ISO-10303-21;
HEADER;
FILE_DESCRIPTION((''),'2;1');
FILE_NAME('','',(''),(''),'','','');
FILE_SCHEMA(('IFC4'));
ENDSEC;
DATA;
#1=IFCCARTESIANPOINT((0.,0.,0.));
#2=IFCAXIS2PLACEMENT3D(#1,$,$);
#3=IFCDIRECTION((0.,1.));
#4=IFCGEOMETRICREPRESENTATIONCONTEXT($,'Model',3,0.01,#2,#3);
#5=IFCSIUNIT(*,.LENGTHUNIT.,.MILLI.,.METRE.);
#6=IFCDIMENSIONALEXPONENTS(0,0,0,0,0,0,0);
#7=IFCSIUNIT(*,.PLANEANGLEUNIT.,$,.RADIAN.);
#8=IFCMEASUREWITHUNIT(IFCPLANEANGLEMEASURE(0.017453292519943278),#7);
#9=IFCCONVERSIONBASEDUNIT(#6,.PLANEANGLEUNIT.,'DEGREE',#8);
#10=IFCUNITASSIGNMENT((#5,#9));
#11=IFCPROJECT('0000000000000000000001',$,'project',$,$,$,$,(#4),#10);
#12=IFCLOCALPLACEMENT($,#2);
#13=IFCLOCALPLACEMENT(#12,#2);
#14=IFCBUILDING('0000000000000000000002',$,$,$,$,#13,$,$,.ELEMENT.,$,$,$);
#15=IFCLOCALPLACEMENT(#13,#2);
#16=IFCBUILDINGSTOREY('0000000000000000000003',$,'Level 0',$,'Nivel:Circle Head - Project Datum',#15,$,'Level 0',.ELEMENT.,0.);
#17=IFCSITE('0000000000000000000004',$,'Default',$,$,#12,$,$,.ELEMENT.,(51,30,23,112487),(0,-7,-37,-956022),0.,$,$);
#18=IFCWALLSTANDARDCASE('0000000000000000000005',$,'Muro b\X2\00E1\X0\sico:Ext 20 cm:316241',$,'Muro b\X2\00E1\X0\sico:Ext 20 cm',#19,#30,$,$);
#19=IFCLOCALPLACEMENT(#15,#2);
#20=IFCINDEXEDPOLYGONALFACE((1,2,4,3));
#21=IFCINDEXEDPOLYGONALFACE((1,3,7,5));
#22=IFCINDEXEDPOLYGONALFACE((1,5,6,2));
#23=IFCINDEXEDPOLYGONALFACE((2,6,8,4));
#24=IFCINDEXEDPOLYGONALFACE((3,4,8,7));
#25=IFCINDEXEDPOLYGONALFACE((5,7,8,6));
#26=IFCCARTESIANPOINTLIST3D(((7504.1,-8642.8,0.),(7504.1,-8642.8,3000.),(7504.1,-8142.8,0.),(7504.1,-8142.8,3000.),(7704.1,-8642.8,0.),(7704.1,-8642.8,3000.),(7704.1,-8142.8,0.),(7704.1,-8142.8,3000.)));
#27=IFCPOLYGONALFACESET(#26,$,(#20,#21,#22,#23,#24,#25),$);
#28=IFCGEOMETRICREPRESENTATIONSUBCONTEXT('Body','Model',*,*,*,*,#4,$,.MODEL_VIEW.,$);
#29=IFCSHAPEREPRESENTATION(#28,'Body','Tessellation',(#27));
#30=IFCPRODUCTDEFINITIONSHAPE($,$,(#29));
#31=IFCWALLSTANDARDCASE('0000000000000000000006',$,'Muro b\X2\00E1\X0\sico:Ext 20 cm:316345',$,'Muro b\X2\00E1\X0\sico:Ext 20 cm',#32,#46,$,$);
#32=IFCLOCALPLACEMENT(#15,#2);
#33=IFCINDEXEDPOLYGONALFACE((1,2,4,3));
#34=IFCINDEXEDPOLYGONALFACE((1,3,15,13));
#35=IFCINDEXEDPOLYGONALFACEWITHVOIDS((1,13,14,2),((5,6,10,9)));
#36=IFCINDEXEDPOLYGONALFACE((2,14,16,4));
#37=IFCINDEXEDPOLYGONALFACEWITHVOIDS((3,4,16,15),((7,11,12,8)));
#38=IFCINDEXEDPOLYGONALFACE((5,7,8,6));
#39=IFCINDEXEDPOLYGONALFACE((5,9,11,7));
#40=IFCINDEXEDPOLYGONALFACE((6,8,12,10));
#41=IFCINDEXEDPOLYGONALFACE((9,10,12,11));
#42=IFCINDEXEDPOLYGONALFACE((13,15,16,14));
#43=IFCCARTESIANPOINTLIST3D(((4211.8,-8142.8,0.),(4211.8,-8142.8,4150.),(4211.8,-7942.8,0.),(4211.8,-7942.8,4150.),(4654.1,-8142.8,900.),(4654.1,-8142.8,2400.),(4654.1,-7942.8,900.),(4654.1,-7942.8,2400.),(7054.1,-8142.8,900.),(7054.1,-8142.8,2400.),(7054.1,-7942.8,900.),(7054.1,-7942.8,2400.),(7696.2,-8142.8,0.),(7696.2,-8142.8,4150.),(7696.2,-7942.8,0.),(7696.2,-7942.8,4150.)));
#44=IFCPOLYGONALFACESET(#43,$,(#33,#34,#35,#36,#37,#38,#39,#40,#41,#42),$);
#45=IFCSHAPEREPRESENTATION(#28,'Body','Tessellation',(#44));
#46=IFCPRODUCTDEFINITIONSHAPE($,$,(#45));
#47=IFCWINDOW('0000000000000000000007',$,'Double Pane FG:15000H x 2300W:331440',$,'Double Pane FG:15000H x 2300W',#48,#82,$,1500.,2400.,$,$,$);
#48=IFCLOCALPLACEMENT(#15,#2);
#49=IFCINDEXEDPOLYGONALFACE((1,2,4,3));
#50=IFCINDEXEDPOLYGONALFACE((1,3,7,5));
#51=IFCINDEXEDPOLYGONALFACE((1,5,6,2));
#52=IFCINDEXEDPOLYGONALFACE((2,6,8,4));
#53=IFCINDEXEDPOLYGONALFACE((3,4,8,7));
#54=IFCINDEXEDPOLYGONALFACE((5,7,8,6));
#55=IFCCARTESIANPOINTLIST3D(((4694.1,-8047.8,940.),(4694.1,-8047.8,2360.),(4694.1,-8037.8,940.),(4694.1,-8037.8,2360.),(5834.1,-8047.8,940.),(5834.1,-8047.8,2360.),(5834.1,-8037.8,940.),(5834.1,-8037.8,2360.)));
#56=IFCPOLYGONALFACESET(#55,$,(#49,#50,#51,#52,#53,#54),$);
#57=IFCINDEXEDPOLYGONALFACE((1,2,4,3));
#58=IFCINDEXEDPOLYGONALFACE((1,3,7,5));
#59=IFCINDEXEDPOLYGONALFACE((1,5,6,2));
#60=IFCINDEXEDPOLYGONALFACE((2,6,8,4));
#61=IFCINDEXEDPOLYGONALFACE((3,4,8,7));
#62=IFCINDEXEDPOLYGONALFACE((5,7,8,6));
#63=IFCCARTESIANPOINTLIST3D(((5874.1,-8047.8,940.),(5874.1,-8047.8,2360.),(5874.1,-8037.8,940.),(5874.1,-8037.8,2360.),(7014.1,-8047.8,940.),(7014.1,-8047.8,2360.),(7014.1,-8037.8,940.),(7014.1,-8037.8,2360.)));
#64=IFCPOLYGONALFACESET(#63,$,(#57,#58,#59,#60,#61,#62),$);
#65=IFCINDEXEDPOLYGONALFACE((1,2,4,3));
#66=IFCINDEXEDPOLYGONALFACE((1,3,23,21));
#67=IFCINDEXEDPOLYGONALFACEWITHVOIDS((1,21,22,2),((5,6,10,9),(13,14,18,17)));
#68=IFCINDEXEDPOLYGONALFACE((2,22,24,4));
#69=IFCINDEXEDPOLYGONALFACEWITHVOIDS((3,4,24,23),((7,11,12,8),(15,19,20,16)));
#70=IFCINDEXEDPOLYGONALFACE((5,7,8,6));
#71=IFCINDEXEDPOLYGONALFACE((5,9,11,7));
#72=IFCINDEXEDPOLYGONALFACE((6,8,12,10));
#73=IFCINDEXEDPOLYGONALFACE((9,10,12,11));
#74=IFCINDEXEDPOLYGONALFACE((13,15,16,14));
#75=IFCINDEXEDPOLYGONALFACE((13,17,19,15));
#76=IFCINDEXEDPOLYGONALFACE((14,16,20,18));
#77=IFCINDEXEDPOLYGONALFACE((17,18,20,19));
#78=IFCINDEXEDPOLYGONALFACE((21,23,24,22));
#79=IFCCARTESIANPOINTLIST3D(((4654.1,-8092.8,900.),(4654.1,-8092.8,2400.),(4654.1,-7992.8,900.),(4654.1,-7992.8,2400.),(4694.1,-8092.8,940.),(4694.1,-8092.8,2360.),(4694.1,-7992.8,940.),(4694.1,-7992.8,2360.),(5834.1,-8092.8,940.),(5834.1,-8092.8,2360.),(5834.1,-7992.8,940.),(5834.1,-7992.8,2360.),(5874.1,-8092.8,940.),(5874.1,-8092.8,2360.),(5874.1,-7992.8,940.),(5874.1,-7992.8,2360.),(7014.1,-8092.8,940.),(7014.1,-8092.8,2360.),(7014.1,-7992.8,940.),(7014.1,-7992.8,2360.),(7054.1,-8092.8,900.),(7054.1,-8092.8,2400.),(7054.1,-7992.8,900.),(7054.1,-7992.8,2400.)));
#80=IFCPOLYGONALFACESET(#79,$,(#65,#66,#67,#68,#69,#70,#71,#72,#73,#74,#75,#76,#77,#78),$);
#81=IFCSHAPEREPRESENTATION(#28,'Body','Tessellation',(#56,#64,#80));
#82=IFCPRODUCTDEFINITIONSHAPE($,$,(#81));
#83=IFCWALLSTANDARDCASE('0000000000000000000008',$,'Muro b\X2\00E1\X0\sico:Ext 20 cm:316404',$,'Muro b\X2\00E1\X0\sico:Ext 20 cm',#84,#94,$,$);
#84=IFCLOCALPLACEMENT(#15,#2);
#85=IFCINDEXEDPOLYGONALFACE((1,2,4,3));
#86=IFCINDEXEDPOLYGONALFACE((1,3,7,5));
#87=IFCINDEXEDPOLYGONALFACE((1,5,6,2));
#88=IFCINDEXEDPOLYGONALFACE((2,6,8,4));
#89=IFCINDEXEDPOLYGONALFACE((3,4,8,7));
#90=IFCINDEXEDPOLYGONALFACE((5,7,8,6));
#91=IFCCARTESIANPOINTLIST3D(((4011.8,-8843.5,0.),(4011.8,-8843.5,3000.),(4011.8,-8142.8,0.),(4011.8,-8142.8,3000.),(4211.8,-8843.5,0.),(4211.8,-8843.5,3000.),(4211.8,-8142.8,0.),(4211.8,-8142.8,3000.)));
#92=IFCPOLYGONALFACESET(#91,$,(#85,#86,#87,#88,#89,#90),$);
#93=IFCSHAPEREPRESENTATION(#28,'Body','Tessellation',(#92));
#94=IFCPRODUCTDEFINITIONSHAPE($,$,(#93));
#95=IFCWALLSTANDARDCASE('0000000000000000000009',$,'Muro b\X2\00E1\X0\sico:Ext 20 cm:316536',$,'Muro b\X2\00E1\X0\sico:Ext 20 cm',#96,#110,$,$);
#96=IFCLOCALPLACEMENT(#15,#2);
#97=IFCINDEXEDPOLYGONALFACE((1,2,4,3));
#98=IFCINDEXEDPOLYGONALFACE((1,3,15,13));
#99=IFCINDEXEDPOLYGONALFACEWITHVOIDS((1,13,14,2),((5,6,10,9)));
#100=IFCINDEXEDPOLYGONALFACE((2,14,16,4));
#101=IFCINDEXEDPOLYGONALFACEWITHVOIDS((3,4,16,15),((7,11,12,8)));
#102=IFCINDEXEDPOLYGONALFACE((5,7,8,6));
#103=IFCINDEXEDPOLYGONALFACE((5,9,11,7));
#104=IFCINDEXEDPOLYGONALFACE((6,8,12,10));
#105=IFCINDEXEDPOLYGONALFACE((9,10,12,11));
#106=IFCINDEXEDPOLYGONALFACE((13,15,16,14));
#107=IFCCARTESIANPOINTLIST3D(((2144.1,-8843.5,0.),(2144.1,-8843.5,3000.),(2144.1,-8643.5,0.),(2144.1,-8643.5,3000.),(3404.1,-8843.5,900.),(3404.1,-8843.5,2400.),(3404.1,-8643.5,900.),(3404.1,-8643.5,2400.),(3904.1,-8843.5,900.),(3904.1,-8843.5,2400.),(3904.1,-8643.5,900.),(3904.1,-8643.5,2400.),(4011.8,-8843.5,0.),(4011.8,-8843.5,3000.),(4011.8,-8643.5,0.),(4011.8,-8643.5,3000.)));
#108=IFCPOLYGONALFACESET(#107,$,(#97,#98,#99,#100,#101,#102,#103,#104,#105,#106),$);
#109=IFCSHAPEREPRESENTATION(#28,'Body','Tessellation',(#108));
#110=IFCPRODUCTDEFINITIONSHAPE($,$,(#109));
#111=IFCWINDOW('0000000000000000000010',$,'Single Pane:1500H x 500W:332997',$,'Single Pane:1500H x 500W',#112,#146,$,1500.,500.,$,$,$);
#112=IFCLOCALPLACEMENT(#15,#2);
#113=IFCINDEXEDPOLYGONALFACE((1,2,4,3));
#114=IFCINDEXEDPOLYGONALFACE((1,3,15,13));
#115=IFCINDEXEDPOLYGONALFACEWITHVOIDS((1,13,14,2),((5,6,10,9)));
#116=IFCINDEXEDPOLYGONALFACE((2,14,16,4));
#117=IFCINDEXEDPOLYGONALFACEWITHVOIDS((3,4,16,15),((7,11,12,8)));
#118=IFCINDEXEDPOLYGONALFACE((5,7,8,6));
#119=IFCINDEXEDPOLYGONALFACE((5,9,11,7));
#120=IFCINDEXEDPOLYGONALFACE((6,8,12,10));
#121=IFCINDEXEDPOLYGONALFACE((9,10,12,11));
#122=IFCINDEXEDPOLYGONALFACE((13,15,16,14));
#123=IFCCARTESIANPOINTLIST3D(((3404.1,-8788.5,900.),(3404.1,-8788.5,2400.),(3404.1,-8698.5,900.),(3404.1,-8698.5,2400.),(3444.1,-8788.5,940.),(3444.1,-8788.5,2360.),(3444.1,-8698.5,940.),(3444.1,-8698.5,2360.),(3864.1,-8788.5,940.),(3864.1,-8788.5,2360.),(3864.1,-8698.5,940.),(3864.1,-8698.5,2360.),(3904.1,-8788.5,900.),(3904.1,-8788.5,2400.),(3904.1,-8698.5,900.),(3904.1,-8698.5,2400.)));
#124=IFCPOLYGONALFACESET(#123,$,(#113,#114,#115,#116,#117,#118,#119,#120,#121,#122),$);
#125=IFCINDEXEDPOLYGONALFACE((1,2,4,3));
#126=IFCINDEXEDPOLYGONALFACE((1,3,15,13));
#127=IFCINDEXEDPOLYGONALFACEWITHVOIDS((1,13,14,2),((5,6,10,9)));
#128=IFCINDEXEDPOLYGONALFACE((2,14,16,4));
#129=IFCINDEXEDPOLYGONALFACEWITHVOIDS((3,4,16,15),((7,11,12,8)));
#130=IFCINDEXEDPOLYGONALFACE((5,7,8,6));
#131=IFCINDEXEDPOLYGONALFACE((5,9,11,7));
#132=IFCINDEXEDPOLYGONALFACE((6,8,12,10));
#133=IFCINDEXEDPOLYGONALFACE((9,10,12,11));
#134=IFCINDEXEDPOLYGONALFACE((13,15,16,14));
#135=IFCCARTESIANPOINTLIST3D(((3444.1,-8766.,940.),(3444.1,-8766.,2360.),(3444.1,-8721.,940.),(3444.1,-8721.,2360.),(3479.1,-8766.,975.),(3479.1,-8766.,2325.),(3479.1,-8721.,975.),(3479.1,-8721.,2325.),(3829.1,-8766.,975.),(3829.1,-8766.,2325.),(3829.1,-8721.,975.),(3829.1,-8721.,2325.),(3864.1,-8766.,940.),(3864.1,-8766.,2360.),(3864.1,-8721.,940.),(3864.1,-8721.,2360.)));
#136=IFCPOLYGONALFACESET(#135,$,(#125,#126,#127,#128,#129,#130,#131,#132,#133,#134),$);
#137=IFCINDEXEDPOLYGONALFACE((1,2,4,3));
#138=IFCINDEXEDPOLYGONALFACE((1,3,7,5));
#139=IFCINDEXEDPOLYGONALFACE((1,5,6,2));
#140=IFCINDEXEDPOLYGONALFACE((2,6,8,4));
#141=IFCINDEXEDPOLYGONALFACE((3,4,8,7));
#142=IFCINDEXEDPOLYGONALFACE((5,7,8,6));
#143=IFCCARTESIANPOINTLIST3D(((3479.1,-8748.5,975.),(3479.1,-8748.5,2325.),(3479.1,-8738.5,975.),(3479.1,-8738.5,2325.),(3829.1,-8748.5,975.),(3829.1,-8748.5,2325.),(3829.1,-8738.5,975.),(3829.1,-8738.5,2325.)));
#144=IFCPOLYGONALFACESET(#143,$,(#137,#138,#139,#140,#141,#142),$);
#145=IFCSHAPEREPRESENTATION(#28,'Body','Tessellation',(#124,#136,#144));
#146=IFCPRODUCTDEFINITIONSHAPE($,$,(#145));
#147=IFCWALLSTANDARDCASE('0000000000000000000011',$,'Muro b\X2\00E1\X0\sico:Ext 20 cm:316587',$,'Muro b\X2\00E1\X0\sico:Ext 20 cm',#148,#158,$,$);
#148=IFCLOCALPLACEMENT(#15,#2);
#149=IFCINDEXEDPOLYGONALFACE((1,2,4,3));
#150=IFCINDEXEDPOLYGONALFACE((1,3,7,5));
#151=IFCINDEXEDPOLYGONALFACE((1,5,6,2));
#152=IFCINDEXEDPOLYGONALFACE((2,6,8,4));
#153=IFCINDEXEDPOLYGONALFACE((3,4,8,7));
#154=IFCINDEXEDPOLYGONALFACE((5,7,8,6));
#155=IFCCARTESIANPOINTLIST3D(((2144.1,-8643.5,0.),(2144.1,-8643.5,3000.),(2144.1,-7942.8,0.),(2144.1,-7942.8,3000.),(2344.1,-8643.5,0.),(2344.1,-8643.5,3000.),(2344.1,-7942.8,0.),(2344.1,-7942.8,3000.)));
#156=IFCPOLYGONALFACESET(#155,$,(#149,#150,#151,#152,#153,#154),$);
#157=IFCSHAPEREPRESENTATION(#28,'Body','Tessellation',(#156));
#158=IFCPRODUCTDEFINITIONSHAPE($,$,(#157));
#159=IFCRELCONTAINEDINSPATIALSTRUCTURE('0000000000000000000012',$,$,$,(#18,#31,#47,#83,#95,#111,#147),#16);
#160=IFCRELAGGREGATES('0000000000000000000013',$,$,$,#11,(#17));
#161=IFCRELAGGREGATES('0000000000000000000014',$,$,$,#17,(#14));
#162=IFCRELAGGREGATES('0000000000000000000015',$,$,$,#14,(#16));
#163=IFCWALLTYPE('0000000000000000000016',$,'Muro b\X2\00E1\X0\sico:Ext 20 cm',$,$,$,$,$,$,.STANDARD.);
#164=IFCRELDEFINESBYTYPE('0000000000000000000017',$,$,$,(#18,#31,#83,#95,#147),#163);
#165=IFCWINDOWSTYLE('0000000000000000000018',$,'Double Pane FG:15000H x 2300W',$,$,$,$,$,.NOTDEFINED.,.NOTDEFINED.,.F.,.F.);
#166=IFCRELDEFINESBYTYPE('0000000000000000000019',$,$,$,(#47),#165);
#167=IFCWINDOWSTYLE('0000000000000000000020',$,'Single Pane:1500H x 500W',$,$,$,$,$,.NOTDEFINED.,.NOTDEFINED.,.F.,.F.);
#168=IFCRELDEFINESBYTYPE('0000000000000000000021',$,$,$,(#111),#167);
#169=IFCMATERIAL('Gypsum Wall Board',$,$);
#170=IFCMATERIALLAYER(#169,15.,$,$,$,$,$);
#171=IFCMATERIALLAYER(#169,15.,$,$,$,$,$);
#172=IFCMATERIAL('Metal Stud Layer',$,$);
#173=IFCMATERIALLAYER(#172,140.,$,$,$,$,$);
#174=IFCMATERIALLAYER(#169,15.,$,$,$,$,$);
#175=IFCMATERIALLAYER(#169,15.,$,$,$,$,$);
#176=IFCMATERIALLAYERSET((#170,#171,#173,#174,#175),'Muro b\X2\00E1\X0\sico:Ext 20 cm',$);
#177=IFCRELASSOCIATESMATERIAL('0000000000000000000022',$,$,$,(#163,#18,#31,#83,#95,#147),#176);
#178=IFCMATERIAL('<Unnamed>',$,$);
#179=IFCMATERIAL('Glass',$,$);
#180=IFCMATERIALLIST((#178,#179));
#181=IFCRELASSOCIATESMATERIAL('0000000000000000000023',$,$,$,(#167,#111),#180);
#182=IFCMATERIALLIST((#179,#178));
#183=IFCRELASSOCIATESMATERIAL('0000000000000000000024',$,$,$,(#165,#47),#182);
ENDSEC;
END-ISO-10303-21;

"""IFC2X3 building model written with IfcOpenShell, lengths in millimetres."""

from ifc_helpers import new_model, entity, si_unit, converted_unit, direction, frame, frame_2d, origin, origin_2d_with_axis, place, context, subcontext, project, spatial, polyline, rectangle, outline, extrude, source, transform, mapped, material, material_list, layer, layer_set, layer_usage, type_object, type_shapes, element, fill, save


model = new_model("IFC2X3")

# Units and contexts
model_context = context("Model", 3, precision=0.01, world=origin(), true_north=direction((0.0, 1.0)))
body_context = subcontext(model_context, "Body", "Model", "MODEL_VIEW")
ifc_project = project(units=[si_unit("LENGTHUNIT", "METRE", prefix="MILLI"), converted_unit("PLANEANGLEUNIT", "DEGREE", entity("IfcPlaneAngleMeasure", 0.017453292519943278), si_unit("PLANEANGLEUNIT", "RADIAN"), dimensions=[0, 0, 0, 0, 0, 0, 0])], contexts=[model_context])

# Site, building, storey
site_placement = place(None, origin())
site = spatial("IfcSite", under=ifc_project, at=site_placement, Name="Default", CompositionType="ELEMENT", RefLatitude=(51, 30, 23, 112487), RefLongitude=(0, -7, -37, -956022), RefElevation=0.0)
building_placement = place(site_placement, origin())
building = spatial("IfcBuilding", under=site, at=building_placement, CompositionType="ELEMENT")
storey_placement = place(building_placement, origin())
storey = spatial("IfcBuildingStorey", under=building, at=storey_placement, Name="Level 0", ObjectType="Nivel:Circle Head - Project Datum", LongName="Level 0", CompositionType="ELEMENT", Elevation=0.0)

# Shared definitions
ifc_material_1 = material(Name="Gypsum Wall Board")
ifc_layer_1 = layer(ifc_material_1, 15.0)
ifc_layer_2 = layer(ifc_material_1, 15.0)
ifc_material_2 = material(Name="Metal Stud Layer")
ifc_layer_3 = layer(ifc_material_2, 140.0)
ifc_layer_4 = layer(ifc_material_1, 15.0)
ifc_layer_5 = layer(ifc_material_1, 15.0)
ifc_layer_set_1 = layer_set([ifc_layer_1, ifc_layer_2, ifc_layer_3, ifc_layer_4, ifc_layer_5], Name="Muro básico:Ext 20 cm")
wall_type_1 = type_object("IfcWallType", Name="Muro básico:Ext 20 cm", PredefinedType="STANDARD", material=ifc_layer_set_1)
ifc_material_3 = material(Name="Glass")
ifc_material_4 = material(Name="<Unnamed>")
ifc_material_list_1 = material_list([ifc_material_3, ifc_material_4])

# Shared definitions
ifc_material_list_2 = material_list([ifc_material_4, ifc_material_3])

# Shared definitions
window_style_1 = type_object("IfcWindowStyle", Name="Single Pane:1500H x 500W", ConstructionType="NOTDEFINED", OperationType="NOTDEFINED", ParameterTakesPrecedence=False, Sizeable=False, material=ifc_material_list_2)
shared_shape_1 = source(origin(), body_context, "Body", "SweptSolid", [
    extrude(outline(polyline([(-250.0, -750.0), (250.0, -750.0), (250.0, 750.0), (-250.0, 750.0), (-250.0, -750.0)]), holes=[polyline([(-210.0, -710.0), (-210.0, 710.0), (210.0, 710.0), (210.0, -710.0), (-210.0, -710.0)])]), frame((250.0, 55.0, 750.0), z_axis=(0.0, 1.0, 0.0), x_axis=(1.0, 0.0, 0.0)), (0.0, 0.0, 1.0), 90.0),
    extrude(outline(polyline([(-210.0, -710.0), (210.0, -710.0), (210.0, 710.0), (-210.0, 710.0), (-210.0, -710.0)]), holes=[polyline([(-175.0, -675.0), (-175.0, 675.0), (175.0, 675.0), (175.0, -675.0), (-175.0, -675.0)])]), frame((250.0, 77.5, 750.0), z_axis=(0.0, 1.0, 0.0), x_axis=(1.0, 0.0, 0.0)), (0.0, 0.0, 1.0), 45.0),
    extrude(rectangle(XDim=10.0, YDim=350.0, at=origin_2d_with_axis()), frame((250.0, 100.0, 75.0), z_axis=(0.0, 0.0, 1.0), x_axis=(0.0, 1.0, 0.0)), (0.0, 0.0, 1.0), 1350.0),
])
type_shapes(window_style_1, [shared_shape_1])

# Wall
ifc_layer_usage_1 = layer_usage(ifc_layer_set_1, "AXIS2", "NEGATIVE", 100.0)
wall_1_placement = place(storey_placement, frame((7604.1, -8642.8, 0.0), z_axis=(0.0, 0.0, 1.0), x_axis=(0.0, 1.0, 0.0)))
element("IfcWallStandardCase", 1, at=wall_1_placement, inside=storey, type_object=wall_type_1, material=ifc_layer_usage_1, Name="Muro básico:Ext 20 cm:316241", ObjectType="Muro básico:Ext 20 cm", context=body_context, shape_type="SweptSolid", body=[
    extrude(rectangle(XDim=500.0, YDim=200.0, at=frame_2d((250.0, 0.0), x_axis=(-1.0, 0.0))), origin(), (0.0, 0.0, 1.0), 3000.0),
])

# Wall, opening, window
ifc_layer_usage_2 = layer_usage(ifc_layer_set_1, "AXIS2", "NEGATIVE", 100.0)
wall_2_placement = place(storey_placement, frame((7696.2, -8042.8, 0.0), z_axis=(0.0, 0.0, 1.0), x_axis=(-1.0, 0.0, 0.0)))
wall_2 = element("IfcWallStandardCase", 2, at=wall_2_placement, inside=storey, type_object=wall_type_1, material=ifc_layer_usage_2, Name="Muro básico:Ext 20 cm:316345", ObjectType="Muro básico:Ext 20 cm", context=body_context, shape_type="SweptSolid", body=[
    extrude(rectangle(XDim=3484.5, YDim=200.0, at=frame_2d((1742.2, 0.0), x_axis=(-1.0, 0.0))), origin(), (0.0, 0.0, 1.0), 4150.0),
])
opening_1_placement = place(wall_2_placement, frame((642.1, -100.0, 900.0)))
opening_1 = element("IfcOpeningElement", 3, at=opening_1_placement, cuts=wall_2, ObjectType="Opening", context=body_context, shape_type="SweptSolid", body=[
    extrude(rectangle(XDim=1500.0, YDim=2400.0, at=frame_2d((750.0, 1200.0), x_axis=(1.0, 0.0))), frame((0.0, 0.0, 0.0), z_axis=(0.0, 1.0, 0.0), x_axis=(0.0, 0.0, 1.0)), (0.0, 0.0, 1.0), 200.0),
])
window_style_2 = type_object("IfcWindowStyle", Name="Double Pane FG:15000H x 2300W", ConstructionType="NOTDEFINED", OperationType="NOTDEFINED", ParameterTakesPrecedence=False, Sizeable=False, material=ifc_material_list_1)
shared_shape_2 = source(origin(), body_context, "Body", "SweptSolid", [
    extrude(rectangle(XDim=10.0, YDim=1140.0, at=origin_2d_with_axis()), frame((1790.0, 100.0, 40.0), z_axis=(0.0, 0.0, 1.0), x_axis=(0.0, 1.0, 0.0)), (0.0, 0.0, 1.0), 1420.0),
    extrude(rectangle(XDim=10.0, YDim=1140.0, at=origin_2d_with_axis()), frame((610.0, 100.0, 40.0), z_axis=(0.0, 0.0, 1.0), x_axis=(0.0, 1.0, 0.0)), (0.0, 0.0, 1.0), 1420.0),
    extrude(outline(polyline([(-750.0, -1200.0), (750.0, -1200.0), (750.0, 1200.0), (-750.0, 1200.0), (-750.0, -1200.0)]), holes=[polyline([(710.0, -20.0), (710.0, -1160.0), (-710.0, -1160.0), (-710.0, -20.0), (710.0, -20.0)]), polyline([(-710.0, 20.0), (-710.0, 1160.0), (710.0, 1160.0), (710.0, 20.0), (-710.0, 20.0)])]), frame((1200.0, 50.0, 750.0), z_axis=(0.0, 1.0, 0.0), x_axis=(0.0, 0.0, -1.0)), (0.0, 0.0, 1.0), 100.0),
])
type_shapes(window_style_2, [shared_shape_2])
window_1_placement = place(opening_1_placement, origin())
window_1 = element("IfcWindow", 4, at=window_1_placement, inside=storey, type_object=window_style_2, material=ifc_material_list_1, Name="Double Pane FG:15000H x 2300W:331440", ObjectType="Double Pane FG:15000H x 2300W", OverallHeight=1500.0, OverallWidth=2400.0, context=body_context, shape_type="MappedRepresentation", body=[
    mapped(shared_shape_2, transform((0.0, 0.0, 0.0), scale=1.0)),
])
fill(opening_1, window_1)

# Wall
ifc_layer_usage_3 = layer_usage(ifc_layer_set_1, "AXIS2", "NEGATIVE", 100.0)
wall_3_placement = place(storey_placement, frame((4111.8, -8142.8, 0.0), z_axis=(0.0, 0.0, 1.0), x_axis=(0.0, -1.0, 0.0)))
element("IfcWallStandardCase", 5, at=wall_3_placement, inside=storey, type_object=wall_type_1, material=ifc_layer_usage_3, Name="Muro básico:Ext 20 cm:316404", ObjectType="Muro básico:Ext 20 cm", context=body_context, shape_type="SweptSolid", body=[
    extrude(rectangle(XDim=700.7, YDim=200.0, at=frame_2d((350.4, 0.0), x_axis=(-1.0, 0.0))), origin(), (0.0, 0.0, 1.0), 3000.0),
])

# Wall, opening, window
ifc_layer_usage_4 = layer_usage(ifc_layer_set_1, "AXIS2", "NEGATIVE", 100.0)
wall_4_placement = place(storey_placement, frame((4011.8, -8743.5, 0.0), z_axis=(0.0, 0.0, 1.0), x_axis=(-1.0, 0.0, 0.0)))
wall_4 = element("IfcWallStandardCase", 6, at=wall_4_placement, inside=storey, type_object=wall_type_1, material=ifc_layer_usage_4, Name="Muro básico:Ext 20 cm:316536", ObjectType="Muro básico:Ext 20 cm", context=body_context, shape_type="SweptSolid", body=[
    extrude(rectangle(XDim=1867.7, YDim=200.0, at=frame_2d((933.8, 0.0), x_axis=(-1.0, 0.0))), origin(), (0.0, 0.0, 1.0), 3000.0),
])
opening_2_placement = place(wall_4_placement, frame((607.7, 100.0, 900.0)))
opening_2 = element("IfcOpeningElement", 7, at=opening_2_placement, cuts=wall_4, ObjectType="Opening", context=body_context, shape_type="SweptSolid", body=[
    extrude(rectangle(XDim=1500.0, YDim=500.0, at=frame_2d((750.0, 250.0), x_axis=(1.0, 0.0))), frame((0.0, 0.0, 0.0), z_axis=(0.0, -1.0, 0.0), x_axis=(0.0, 0.0, 1.0)), (0.0, 0.0, 1.0), 200.0),
])
window_2_placement = place(opening_2_placement, frame((0.0, 0.0, 0.0), z_axis=(0.0, 0.0, 1.0), x_axis=(-1.0, 0.0, 0.0)))
window_2 = element("IfcWindow", 8, at=window_2_placement, inside=storey, type_object=window_style_1, material=ifc_material_list_2, Name="Single Pane:1500H x 500W:332997", ObjectType="Single Pane:1500H x 500W", OverallHeight=1500.0, OverallWidth=500.0, context=body_context, shape_type="MappedRepresentation", body=[
    mapped(shared_shape_1, transform((0.0, 0.0, 0.0), scale=1.0)),
])
fill(opening_2, window_2)

# Wall
ifc_layer_usage_5 = layer_usage(ifc_layer_set_1, "AXIS2", "NEGATIVE", 100.0)
wall_5_placement = place(storey_placement, frame((2244.1, -8643.5, 0.0), z_axis=(0.0, 0.0, 1.0), x_axis=(0.0, 1.0, 0.0)))
element("IfcWallStandardCase", 9, at=wall_5_placement, inside=storey, type_object=wall_type_1, material=ifc_layer_usage_5, Name="Muro básico:Ext 20 cm:316587", ObjectType="Muro básico:Ext 20 cm", context=body_context, shape_type="SweptSolid", body=[
    extrude(rectangle(XDim=700.7, YDim=200.0, at=frame_2d((350.4, 0.0), x_axis=(-1.0, 0.0))), origin(), (0.0, 0.0, 1.0), 3000.0),
])

save(model, "model.ifc")
